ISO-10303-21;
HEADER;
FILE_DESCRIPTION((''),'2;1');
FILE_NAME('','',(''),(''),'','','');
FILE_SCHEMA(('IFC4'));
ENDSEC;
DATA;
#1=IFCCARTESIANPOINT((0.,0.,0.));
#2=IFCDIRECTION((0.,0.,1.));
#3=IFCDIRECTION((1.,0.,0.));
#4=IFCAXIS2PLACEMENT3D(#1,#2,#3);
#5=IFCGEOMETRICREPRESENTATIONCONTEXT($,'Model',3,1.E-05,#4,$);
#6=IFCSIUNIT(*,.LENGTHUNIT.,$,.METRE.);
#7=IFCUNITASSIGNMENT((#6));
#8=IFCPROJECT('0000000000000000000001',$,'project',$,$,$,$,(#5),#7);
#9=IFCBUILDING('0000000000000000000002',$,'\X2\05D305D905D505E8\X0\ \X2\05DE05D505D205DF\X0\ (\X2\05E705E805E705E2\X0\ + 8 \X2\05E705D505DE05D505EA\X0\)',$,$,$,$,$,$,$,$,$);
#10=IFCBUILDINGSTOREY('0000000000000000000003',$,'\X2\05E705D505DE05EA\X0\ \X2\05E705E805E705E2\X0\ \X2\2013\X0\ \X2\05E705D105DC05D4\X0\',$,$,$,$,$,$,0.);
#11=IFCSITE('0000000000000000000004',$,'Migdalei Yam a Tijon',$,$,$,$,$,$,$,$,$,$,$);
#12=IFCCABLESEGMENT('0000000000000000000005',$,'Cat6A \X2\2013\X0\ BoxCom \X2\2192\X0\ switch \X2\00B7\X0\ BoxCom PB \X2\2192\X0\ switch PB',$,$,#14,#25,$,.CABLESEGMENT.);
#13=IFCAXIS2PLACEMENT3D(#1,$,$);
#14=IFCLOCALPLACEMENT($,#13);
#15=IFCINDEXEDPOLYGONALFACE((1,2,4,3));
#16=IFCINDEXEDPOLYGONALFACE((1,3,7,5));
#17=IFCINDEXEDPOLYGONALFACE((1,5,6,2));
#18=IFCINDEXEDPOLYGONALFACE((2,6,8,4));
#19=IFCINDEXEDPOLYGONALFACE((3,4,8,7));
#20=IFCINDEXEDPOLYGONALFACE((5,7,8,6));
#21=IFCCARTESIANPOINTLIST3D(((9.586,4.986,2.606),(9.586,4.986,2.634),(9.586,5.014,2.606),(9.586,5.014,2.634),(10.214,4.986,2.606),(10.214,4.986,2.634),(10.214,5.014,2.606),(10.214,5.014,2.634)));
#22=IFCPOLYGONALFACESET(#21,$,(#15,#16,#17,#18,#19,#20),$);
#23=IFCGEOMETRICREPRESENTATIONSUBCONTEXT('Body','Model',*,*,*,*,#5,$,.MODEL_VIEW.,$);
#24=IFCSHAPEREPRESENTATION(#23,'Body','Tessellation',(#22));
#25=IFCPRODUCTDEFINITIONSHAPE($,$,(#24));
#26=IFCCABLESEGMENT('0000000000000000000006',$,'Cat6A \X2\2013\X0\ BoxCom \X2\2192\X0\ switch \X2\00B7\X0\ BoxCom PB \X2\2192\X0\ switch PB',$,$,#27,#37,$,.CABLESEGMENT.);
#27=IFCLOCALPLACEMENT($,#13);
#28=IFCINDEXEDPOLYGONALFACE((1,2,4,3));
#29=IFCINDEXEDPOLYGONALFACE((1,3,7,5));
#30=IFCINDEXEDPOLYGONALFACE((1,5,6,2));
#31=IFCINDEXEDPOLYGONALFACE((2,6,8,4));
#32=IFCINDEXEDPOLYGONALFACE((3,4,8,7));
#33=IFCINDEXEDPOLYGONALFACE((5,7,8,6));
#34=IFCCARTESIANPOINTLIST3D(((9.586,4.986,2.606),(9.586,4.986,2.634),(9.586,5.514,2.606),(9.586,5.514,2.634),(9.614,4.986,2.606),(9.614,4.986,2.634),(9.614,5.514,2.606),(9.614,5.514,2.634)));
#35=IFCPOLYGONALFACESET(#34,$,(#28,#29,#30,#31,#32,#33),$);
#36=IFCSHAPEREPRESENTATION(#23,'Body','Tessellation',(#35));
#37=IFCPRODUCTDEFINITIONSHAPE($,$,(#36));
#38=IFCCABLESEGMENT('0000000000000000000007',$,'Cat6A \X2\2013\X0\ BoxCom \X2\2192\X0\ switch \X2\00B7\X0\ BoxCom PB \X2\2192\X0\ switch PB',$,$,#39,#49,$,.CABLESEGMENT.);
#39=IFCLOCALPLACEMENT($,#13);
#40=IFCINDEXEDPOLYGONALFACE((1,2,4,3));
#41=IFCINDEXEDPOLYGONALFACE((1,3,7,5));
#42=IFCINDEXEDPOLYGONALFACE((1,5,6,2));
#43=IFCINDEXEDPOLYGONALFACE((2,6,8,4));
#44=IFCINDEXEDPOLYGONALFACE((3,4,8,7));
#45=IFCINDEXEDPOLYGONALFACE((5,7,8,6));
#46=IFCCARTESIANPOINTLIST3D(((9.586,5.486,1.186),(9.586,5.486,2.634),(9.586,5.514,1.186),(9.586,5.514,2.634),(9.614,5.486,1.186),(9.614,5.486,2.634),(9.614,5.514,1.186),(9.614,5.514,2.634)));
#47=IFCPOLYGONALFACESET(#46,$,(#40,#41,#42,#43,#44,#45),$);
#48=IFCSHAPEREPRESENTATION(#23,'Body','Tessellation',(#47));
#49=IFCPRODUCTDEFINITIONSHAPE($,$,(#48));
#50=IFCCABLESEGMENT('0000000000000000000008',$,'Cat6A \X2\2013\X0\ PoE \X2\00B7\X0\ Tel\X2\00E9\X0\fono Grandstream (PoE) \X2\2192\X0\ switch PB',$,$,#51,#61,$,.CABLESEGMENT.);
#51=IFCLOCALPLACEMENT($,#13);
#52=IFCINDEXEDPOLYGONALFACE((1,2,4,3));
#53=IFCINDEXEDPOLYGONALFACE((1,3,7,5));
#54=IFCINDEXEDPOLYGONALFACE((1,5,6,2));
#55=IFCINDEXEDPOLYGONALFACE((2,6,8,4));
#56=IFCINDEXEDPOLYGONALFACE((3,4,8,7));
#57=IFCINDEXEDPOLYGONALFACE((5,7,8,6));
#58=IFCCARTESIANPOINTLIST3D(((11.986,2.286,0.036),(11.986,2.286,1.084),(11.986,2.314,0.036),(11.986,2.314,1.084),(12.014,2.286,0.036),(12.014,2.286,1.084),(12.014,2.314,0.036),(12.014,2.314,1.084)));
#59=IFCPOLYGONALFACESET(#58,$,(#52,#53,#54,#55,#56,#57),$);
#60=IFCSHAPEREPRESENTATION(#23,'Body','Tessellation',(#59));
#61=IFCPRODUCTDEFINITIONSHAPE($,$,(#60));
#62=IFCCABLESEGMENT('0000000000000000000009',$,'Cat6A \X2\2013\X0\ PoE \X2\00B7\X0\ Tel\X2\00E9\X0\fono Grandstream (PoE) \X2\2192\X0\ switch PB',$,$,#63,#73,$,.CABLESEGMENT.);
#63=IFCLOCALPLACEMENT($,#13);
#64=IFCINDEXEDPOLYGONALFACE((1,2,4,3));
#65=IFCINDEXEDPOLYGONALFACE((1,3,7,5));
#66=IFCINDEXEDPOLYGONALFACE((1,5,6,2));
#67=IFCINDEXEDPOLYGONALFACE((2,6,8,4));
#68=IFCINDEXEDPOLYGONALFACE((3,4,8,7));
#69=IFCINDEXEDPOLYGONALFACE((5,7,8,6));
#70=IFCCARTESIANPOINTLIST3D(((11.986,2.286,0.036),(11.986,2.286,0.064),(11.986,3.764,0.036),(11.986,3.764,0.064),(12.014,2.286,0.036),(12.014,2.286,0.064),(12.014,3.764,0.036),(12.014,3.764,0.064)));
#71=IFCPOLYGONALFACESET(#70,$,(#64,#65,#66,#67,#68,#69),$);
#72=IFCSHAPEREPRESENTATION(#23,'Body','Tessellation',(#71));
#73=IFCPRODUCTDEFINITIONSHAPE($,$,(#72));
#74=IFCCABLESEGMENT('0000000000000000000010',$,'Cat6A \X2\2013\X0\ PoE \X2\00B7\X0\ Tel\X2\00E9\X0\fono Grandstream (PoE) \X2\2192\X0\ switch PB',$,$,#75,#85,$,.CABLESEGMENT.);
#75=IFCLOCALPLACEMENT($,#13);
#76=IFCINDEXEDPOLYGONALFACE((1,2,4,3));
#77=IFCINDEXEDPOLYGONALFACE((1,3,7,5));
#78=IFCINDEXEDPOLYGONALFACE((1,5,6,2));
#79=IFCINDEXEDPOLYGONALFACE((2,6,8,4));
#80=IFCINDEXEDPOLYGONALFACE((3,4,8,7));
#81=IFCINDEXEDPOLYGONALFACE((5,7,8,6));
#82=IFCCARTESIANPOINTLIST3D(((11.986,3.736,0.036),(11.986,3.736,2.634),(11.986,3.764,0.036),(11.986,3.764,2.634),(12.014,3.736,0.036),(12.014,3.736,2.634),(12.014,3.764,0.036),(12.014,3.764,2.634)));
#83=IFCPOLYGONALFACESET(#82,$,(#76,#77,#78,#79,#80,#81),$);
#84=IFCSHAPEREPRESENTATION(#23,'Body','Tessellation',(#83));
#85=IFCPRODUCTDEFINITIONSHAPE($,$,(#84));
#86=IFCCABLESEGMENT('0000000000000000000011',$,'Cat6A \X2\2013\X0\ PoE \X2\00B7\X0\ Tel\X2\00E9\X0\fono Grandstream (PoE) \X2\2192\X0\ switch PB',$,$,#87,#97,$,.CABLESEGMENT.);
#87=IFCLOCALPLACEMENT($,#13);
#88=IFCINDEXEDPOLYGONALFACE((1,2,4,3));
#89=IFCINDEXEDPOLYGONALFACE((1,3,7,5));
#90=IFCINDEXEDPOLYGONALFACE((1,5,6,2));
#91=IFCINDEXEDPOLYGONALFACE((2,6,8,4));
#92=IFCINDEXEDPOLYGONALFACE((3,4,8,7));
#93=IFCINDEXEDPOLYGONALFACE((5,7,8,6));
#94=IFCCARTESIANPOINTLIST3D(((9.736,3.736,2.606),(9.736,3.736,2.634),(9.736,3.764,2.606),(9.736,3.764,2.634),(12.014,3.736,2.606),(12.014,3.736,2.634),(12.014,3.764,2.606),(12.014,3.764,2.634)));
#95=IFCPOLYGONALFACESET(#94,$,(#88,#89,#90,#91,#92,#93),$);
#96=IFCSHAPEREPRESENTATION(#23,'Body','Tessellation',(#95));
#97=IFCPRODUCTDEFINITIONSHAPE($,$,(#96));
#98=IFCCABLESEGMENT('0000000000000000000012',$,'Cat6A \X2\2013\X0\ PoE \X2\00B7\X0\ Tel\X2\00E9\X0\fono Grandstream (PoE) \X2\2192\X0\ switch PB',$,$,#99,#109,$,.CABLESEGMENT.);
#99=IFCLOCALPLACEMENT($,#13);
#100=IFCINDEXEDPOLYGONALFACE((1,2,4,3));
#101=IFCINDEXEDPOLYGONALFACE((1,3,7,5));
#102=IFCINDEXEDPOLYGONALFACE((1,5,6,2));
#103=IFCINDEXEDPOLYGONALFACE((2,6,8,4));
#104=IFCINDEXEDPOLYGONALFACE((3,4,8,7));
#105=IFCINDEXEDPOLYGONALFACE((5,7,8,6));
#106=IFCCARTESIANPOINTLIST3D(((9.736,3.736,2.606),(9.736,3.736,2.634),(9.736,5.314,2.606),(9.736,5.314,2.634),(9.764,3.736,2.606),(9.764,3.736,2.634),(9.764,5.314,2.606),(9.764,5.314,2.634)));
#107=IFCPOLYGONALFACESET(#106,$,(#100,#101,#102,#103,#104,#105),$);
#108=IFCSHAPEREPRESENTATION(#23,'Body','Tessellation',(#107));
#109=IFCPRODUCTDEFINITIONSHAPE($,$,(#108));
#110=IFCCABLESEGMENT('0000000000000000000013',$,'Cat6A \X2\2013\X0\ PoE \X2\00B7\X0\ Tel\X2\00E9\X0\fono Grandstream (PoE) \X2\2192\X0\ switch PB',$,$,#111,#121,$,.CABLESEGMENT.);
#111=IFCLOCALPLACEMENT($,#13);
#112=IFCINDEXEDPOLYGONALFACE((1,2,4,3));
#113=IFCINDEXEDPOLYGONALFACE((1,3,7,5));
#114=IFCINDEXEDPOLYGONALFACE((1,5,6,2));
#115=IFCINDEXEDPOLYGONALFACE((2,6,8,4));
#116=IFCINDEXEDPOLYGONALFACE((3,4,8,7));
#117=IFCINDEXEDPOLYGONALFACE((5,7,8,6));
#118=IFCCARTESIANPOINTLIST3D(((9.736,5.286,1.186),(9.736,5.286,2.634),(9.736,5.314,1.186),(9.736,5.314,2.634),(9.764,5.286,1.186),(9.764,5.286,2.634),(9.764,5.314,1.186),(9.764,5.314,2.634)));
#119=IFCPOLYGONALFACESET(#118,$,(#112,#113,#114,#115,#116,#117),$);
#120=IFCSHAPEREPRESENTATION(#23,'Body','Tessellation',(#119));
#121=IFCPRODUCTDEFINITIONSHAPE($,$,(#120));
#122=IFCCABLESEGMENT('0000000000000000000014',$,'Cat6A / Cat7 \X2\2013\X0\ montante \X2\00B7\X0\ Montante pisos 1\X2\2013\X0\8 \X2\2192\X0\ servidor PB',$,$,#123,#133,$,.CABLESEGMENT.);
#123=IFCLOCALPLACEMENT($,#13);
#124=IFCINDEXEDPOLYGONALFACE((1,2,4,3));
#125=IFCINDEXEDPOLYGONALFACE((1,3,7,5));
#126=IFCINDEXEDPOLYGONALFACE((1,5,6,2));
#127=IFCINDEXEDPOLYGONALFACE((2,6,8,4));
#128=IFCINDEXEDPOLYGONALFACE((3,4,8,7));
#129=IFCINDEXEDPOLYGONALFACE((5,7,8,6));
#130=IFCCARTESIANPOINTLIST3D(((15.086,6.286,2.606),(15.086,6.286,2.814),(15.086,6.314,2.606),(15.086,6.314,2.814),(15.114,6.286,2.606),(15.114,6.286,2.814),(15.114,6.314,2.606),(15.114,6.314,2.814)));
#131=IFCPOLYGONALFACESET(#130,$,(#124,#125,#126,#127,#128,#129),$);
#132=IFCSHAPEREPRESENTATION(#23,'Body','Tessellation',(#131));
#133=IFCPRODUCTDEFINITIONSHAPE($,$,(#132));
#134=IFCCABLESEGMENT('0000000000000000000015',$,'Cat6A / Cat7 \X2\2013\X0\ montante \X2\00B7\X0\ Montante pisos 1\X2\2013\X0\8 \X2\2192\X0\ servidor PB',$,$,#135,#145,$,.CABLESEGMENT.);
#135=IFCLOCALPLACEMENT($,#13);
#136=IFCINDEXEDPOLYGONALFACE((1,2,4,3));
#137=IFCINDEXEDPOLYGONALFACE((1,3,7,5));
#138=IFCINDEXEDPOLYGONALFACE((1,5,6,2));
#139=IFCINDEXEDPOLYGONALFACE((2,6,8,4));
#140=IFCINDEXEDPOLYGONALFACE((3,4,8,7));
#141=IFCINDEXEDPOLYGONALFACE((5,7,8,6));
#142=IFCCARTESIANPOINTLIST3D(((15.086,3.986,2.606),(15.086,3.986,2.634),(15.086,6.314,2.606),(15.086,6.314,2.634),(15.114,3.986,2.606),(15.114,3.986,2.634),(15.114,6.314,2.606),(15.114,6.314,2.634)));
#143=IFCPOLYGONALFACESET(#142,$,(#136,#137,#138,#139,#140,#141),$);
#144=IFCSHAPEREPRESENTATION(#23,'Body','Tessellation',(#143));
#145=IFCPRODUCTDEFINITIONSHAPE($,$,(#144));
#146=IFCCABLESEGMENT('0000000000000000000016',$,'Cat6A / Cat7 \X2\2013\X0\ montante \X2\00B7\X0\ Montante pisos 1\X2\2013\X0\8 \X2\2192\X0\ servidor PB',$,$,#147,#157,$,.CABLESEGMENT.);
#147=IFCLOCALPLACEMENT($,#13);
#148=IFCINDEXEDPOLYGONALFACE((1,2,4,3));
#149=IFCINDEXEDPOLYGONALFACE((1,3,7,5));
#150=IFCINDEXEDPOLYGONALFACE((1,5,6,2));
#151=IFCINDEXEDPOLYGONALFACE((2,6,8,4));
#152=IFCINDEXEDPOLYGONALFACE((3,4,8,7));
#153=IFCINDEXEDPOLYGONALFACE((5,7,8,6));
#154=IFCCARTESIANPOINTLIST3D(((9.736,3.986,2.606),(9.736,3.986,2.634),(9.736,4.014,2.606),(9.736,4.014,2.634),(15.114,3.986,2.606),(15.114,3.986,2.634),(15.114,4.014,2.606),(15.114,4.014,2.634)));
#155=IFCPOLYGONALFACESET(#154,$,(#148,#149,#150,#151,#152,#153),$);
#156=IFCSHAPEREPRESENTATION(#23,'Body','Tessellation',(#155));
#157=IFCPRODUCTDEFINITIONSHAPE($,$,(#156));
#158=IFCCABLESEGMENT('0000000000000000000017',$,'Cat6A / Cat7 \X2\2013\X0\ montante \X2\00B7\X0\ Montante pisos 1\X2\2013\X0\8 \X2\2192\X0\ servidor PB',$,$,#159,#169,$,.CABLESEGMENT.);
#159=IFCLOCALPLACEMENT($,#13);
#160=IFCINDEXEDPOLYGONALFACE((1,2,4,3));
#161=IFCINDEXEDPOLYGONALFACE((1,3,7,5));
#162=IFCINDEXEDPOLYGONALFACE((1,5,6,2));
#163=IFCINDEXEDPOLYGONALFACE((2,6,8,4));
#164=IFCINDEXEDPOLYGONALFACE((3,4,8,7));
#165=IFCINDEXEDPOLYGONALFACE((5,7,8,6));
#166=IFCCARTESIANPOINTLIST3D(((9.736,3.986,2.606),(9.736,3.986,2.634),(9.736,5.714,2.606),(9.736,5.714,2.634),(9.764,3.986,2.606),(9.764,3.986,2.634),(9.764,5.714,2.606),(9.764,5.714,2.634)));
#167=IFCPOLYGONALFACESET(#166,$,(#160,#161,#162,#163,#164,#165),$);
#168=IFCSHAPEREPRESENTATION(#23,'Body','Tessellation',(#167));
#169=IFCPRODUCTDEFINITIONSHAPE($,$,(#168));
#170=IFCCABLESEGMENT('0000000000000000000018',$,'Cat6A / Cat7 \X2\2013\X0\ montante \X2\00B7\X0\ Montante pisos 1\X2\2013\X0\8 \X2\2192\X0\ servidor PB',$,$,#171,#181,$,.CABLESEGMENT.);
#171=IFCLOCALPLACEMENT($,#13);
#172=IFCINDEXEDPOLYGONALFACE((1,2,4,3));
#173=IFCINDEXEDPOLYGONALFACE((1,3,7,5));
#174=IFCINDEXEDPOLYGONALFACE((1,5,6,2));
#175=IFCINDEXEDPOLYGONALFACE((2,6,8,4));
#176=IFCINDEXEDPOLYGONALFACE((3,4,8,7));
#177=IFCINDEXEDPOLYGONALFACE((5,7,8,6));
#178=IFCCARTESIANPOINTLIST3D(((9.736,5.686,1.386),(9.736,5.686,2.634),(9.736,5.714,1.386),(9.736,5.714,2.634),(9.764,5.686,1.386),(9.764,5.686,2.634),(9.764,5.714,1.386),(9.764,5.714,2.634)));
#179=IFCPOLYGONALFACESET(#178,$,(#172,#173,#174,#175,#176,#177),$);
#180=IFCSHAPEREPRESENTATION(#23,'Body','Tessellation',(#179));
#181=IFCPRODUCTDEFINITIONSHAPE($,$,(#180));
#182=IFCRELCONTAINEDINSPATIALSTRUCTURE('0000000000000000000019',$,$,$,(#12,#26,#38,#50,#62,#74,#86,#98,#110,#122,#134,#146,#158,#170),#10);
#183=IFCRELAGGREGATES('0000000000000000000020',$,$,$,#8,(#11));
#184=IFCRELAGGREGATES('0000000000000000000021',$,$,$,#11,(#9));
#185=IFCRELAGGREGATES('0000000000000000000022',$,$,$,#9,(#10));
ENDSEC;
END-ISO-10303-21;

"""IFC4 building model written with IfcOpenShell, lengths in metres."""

from ifc_helpers import new_model, si_unit, frame, origin_with_axes, context, subcontext, project, spatial, line, indexed_curve, outline, extrude, element, save


model = new_model("IFC4")

# Units and contexts
model_context = context("Model", 3, precision=1e-05, world=origin_with_axes())
body_context = subcontext(model_context, "Body", "Model", "MODEL_VIEW")
ifc_project = project(units=[si_unit("LENGTHUNIT", "METRE")], contexts=[model_context])

# Site, building, storey
site = spatial("IfcSite", under=ifc_project, Name="Migdalei Yam a Tijon")
building = spatial("IfcBuilding", under=site, Name="דיור מוגן (קרקע + 8 קומות)")
storey = spatial("IfcBuildingStorey", under=building, Name="קומת קרקע – קבלה", Elevation=0.0)

# Cable segments
element("IfcCableSegment", 1, inside=storey, Name="Cat6A – BoxCom → switch · BoxCom PB → switch PB", PredefinedType="CABLESEGMENT", context=body_context, shape_type="SweptSolid", body=[
    extrude(outline(indexed_curve([(0.0, 0.0), (0.628, 0.0), (0.628, 0.028), (0.0, 0.028)], segments=[line(1, 2, 3, 4, 1)])), frame((9.586, 4.986, 2.606), z_axis=(0.0, 0.0, 1.0), x_axis=(1.0, 0.0, 0.0)), (0.0, 0.0, 1.0), 0.028),
])
element("IfcCableSegment", 2, inside=storey, Name="Cat6A – BoxCom → switch · BoxCom PB → switch PB", PredefinedType="CABLESEGMENT", context=body_context, shape_type="SweptSolid", body=[
    extrude(outline(indexed_curve([(0.0, 0.0), (0.028, 0.0), (0.028, 0.528), (0.0, 0.528)], segments=[line(1, 2, 3, 4, 1)])), frame((9.586, 4.986, 2.606), z_axis=(0.0, 0.0, 1.0), x_axis=(1.0, 0.0, 0.0)), (0.0, 0.0, 1.0), 0.028),
])
element("IfcCableSegment", 3, inside=storey, Name="Cat6A – BoxCom → switch · BoxCom PB → switch PB", PredefinedType="CABLESEGMENT", context=body_context, shape_type="SweptSolid", body=[
    extrude(outline(indexed_curve([(0.0, 0.0), (0.028, 0.0), (0.028, 0.028), (0.0, 0.028)], segments=[line(1, 2, 3, 4, 1)])), frame((9.586, 5.486, 1.186), z_axis=(0.0, 0.0, 1.0), x_axis=(1.0, 0.0, 0.0)), (0.0, 0.0, 1.0), 1.448),
])
element("IfcCableSegment", 4, inside=storey, Name="Cat6A – PoE · Teléfono Grandstream (PoE) → switch PB", PredefinedType="CABLESEGMENT", context=body_context, shape_type="SweptSolid", body=[
    extrude(outline(indexed_curve([(0.0, 0.0), (0.028, 0.0), (0.028, 0.028), (0.0, 0.028)], segments=[line(1, 2, 3, 4, 1)])), frame((11.986, 2.286, 0.036), z_axis=(0.0, 0.0, 1.0), x_axis=(1.0, 0.0, 0.0)), (0.0, 0.0, 1.0), 1.048),
])
element("IfcCableSegment", 5, inside=storey, Name="Cat6A – PoE · Teléfono Grandstream (PoE) → switch PB", PredefinedType="CABLESEGMENT", context=body_context, shape_type="SweptSolid", body=[
    extrude(outline(indexed_curve([(0.0, 0.0), (0.028, 0.0), (0.028, 1.478), (0.0, 1.478)], segments=[line(1, 2, 3, 4, 1)])), frame((11.986, 2.286, 0.036), z_axis=(0.0, 0.0, 1.0), x_axis=(1.0, 0.0, 0.0)), (0.0, 0.0, 1.0), 0.028),
])
element("IfcCableSegment", 6, inside=storey, Name="Cat6A – PoE · Teléfono Grandstream (PoE) → switch PB", PredefinedType="CABLESEGMENT", context=body_context, shape_type="SweptSolid", body=[
    extrude(outline(indexed_curve([(0.0, 0.0), (0.028, 0.0), (0.028, 0.028), (0.0, 0.028)], segments=[line(1, 2, 3, 4, 1)])), frame((11.986, 3.736, 0.036), z_axis=(0.0, 0.0, 1.0), x_axis=(1.0, 0.0, 0.0)), (0.0, 0.0, 1.0), 2.598),
])
element("IfcCableSegment", 7, inside=storey, Name="Cat6A – PoE · Teléfono Grandstream (PoE) → switch PB", PredefinedType="CABLESEGMENT", context=body_context, shape_type="SweptSolid", body=[
    extrude(outline(indexed_curve([(0.0, 0.0), (2.278, 0.0), (2.278, 0.028), (0.0, 0.028)], segments=[line(1, 2, 3, 4, 1)])), frame((9.736, 3.736, 2.606), z_axis=(0.0, 0.0, 1.0), x_axis=(1.0, 0.0, 0.0)), (0.0, 0.0, 1.0), 0.028),
])
element("IfcCableSegment", 8, inside=storey, Name="Cat6A – PoE · Teléfono Grandstream (PoE) → switch PB", PredefinedType="CABLESEGMENT", context=body_context, shape_type="SweptSolid", body=[
    extrude(outline(indexed_curve([(0.0, 0.0), (0.028, 0.0), (0.028, 1.578), (0.0, 1.578)], segments=[line(1, 2, 3, 4, 1)])), frame((9.736, 3.736, 2.606), z_axis=(0.0, 0.0, 1.0), x_axis=(1.0, 0.0, 0.0)), (0.0, 0.0, 1.0), 0.028),
])
element("IfcCableSegment", 9, inside=storey, Name="Cat6A – PoE · Teléfono Grandstream (PoE) → switch PB", PredefinedType="CABLESEGMENT", context=body_context, shape_type="SweptSolid", body=[
    extrude(outline(indexed_curve([(0.0, 0.0), (0.028, 0.0), (0.028, 0.028), (0.0, 0.028)], segments=[line(1, 2, 3, 4, 1)])), frame((9.736, 5.286, 1.186), z_axis=(0.0, 0.0, 1.0), x_axis=(1.0, 0.0, 0.0)), (0.0, 0.0, 1.0), 1.448),
])
element("IfcCableSegment", 10, inside=storey, Name="Cat6A / Cat7 – montante · Montante pisos 1–8 → servidor PB", PredefinedType="CABLESEGMENT", context=body_context, shape_type="SweptSolid", body=[
    extrude(outline(indexed_curve([(0.0, 0.0), (0.028, 0.0), (0.028, 0.028), (0.0, 0.028)], segments=[line(1, 2, 3, 4, 1)])), frame((15.086, 6.286, 2.606), z_axis=(0.0, 0.0, 1.0), x_axis=(1.0, 0.0, 0.0)), (0.0, 0.0, 1.0), 0.208),
])
element("IfcCableSegment", 11, inside=storey, Name="Cat6A / Cat7 – montante · Montante pisos 1–8 → servidor PB", PredefinedType="CABLESEGMENT", context=body_context, shape_type="SweptSolid", body=[
    extrude(outline(indexed_curve([(0.0, 0.0), (0.028, 0.0), (0.028, 2.328), (0.0, 2.328)], segments=[line(1, 2, 3, 4, 1)])), frame((15.086, 3.986, 2.606), z_axis=(0.0, 0.0, 1.0), x_axis=(1.0, 0.0, 0.0)), (0.0, 0.0, 1.0), 0.028),
])
element("IfcCableSegment", 12, inside=storey, Name="Cat6A / Cat7 – montante · Montante pisos 1–8 → servidor PB", PredefinedType="CABLESEGMENT", context=body_context, shape_type="SweptSolid", body=[
    extrude(outline(indexed_curve([(0.0, 0.0), (5.378, 0.0), (5.378, 0.028), (0.0, 0.028)], segments=[line(1, 2, 3, 4, 1)])), frame((9.736, 3.986, 2.606), z_axis=(0.0, 0.0, 1.0), x_axis=(1.0, 0.0, 0.0)), (0.0, 0.0, 1.0), 0.028),
])
element("IfcCableSegment", 13, inside=storey, Name="Cat6A / Cat7 – montante · Montante pisos 1–8 → servidor PB", PredefinedType="CABLESEGMENT", context=body_context, shape_type="SweptSolid", body=[
    extrude(outline(indexed_curve([(0.0, 0.0), (0.028, 0.0), (0.028, 1.728), (0.0, 1.728)], segments=[line(1, 2, 3, 4, 1)])), frame((9.736, 3.986, 2.606), z_axis=(0.0, 0.0, 1.0), x_axis=(1.0, 0.0, 0.0)), (0.0, 0.0, 1.0), 0.028),
])
element("IfcCableSegment", 14, inside=storey, Name="Cat6A / Cat7 – montante · Montante pisos 1–8 → servidor PB", PredefinedType="CABLESEGMENT", context=body_context, shape_type="SweptSolid", body=[
    extrude(outline(indexed_curve([(0.0, 0.0), (0.028, 0.0), (0.028, 0.028), (0.0, 0.028)], segments=[line(1, 2, 3, 4, 1)])), frame((9.736, 5.686, 1.386), z_axis=(0.0, 0.0, 1.0), x_axis=(1.0, 0.0, 0.0)), (0.0, 0.0, 1.0), 1.248),
])

save(model, "model.ifc")
